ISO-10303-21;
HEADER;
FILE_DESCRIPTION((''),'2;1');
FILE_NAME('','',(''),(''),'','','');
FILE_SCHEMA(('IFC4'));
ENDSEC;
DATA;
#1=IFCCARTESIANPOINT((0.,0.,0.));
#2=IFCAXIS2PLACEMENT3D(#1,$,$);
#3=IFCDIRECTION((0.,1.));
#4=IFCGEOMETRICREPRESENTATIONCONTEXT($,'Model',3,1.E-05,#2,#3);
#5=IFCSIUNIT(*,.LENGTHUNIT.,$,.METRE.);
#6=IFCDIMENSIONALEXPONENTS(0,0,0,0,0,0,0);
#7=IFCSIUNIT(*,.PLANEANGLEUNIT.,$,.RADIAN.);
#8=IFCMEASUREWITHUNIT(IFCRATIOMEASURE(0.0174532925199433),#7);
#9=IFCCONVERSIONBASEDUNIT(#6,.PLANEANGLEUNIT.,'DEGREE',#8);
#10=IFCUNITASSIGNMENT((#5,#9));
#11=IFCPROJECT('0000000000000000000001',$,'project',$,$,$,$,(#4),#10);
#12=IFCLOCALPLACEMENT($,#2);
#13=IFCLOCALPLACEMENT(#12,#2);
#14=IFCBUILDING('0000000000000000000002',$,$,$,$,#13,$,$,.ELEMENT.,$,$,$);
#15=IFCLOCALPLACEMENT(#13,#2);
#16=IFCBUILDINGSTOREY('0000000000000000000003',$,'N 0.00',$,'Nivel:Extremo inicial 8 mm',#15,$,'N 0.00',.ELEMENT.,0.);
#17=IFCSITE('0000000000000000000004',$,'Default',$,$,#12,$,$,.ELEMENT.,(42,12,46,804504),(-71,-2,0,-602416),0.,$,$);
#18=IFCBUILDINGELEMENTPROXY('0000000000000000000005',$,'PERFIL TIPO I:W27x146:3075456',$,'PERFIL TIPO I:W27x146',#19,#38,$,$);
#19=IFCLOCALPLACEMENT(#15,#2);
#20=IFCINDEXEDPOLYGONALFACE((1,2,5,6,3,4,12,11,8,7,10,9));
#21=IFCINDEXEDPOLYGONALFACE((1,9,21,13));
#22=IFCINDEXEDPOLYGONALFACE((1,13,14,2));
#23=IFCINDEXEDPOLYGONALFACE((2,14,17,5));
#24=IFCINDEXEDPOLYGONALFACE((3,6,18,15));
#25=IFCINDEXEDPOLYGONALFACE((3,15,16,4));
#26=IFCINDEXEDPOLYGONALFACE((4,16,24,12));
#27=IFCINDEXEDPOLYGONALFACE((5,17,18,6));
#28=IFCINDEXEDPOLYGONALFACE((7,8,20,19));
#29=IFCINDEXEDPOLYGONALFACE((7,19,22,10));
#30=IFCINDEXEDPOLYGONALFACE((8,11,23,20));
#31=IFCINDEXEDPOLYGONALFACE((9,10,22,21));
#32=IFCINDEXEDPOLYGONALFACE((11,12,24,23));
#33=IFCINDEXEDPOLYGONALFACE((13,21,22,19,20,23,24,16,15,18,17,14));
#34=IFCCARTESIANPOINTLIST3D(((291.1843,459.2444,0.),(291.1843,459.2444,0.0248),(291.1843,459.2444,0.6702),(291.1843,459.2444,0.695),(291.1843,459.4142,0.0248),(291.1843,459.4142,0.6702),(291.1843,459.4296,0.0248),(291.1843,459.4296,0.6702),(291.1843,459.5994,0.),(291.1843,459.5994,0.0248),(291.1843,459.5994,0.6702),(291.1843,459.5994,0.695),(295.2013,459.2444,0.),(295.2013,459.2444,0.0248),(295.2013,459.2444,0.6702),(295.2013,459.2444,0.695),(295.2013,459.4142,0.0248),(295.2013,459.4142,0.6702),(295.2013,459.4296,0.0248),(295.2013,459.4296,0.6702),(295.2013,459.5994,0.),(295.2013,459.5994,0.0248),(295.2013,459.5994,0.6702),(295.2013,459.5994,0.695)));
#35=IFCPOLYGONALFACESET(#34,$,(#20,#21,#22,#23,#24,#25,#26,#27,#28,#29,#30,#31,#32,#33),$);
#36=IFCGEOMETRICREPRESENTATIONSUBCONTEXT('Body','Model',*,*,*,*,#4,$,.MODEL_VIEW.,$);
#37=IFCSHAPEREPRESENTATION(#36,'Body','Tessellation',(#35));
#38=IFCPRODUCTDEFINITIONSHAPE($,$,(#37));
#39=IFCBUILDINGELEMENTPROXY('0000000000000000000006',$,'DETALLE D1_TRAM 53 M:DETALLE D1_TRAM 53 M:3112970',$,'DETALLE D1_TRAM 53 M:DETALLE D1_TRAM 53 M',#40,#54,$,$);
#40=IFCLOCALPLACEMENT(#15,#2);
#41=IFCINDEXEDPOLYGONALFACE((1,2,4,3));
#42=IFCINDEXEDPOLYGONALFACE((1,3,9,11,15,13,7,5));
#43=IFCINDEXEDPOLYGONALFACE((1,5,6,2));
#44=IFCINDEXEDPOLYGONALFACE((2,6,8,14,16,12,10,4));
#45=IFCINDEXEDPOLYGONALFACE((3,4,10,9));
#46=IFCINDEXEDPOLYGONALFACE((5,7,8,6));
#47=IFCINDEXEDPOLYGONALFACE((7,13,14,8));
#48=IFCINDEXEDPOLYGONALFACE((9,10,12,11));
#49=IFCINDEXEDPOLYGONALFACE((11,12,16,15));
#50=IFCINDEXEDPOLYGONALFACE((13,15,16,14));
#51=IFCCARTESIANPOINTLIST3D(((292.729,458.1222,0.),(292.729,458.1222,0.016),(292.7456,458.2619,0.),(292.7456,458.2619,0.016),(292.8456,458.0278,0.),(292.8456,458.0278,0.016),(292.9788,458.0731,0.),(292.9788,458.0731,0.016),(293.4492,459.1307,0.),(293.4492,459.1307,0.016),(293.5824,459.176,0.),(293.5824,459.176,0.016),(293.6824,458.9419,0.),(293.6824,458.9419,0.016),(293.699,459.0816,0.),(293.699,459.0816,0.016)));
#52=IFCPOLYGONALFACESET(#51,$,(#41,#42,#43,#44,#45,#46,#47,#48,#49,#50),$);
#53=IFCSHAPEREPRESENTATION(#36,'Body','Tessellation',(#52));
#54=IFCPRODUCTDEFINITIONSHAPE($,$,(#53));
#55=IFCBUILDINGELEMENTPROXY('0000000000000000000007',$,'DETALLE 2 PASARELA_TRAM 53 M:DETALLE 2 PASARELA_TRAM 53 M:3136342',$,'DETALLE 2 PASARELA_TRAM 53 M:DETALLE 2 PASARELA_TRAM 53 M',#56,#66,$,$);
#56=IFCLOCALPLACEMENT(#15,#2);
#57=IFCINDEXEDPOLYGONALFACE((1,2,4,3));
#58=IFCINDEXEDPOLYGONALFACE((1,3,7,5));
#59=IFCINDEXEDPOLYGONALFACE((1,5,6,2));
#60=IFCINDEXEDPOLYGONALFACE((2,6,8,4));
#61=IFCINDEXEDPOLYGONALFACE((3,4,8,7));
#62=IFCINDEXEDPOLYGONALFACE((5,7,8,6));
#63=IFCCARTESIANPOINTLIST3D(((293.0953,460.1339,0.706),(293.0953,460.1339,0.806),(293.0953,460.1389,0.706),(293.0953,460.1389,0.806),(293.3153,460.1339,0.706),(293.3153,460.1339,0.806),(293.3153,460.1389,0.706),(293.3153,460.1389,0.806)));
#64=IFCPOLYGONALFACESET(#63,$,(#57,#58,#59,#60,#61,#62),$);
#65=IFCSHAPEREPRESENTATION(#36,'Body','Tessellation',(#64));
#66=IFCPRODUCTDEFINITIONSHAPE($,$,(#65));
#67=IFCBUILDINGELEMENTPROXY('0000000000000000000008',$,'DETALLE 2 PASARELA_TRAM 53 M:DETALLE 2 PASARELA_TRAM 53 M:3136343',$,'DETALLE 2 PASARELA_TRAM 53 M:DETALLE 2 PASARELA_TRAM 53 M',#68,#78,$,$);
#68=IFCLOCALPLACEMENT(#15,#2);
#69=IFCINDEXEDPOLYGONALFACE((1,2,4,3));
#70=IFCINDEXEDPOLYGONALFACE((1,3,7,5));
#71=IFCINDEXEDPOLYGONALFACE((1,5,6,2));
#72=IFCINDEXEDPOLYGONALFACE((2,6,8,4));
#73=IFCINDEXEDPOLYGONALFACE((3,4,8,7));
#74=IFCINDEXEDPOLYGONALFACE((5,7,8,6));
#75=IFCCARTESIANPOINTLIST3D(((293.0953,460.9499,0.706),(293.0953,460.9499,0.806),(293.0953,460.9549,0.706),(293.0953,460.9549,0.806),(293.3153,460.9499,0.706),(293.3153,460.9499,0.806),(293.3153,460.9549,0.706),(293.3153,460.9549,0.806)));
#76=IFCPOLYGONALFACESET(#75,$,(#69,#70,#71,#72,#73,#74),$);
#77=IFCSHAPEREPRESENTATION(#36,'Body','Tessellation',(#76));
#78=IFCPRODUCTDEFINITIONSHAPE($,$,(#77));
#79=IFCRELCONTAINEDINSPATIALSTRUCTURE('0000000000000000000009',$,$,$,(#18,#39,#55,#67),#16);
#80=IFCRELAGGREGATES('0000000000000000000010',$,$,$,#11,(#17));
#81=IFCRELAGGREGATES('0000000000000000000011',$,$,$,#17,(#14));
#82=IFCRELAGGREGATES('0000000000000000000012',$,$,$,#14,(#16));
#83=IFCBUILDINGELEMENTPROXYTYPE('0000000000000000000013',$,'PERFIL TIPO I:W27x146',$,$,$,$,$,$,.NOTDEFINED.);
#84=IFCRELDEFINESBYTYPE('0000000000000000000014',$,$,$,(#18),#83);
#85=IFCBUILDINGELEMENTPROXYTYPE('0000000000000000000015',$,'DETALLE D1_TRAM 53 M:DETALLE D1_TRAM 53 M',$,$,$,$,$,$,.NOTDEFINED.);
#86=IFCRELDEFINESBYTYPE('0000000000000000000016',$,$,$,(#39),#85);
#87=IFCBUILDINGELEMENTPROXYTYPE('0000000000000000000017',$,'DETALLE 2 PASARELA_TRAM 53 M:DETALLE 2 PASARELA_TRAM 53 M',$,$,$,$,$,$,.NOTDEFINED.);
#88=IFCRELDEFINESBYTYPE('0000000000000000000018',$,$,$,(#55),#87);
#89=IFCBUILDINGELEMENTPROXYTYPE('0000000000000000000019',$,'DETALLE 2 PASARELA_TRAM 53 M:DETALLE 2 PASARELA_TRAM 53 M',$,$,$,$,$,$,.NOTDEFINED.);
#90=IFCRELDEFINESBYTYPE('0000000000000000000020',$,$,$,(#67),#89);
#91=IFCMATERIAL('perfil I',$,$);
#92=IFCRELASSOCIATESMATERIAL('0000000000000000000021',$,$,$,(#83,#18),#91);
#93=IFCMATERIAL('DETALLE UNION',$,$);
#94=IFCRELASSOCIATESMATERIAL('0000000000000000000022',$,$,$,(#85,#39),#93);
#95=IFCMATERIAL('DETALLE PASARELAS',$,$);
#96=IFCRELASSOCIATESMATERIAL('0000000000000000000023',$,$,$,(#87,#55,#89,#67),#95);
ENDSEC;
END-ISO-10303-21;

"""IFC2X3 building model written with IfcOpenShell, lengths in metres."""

from ifc_helpers import new_model, entity, si_unit, converted_unit, direction, frame, frame_2d, origin, place, context, subcontext, project, spatial, polyline, rectangle, outline, extrude, source, transform, mapped, material, type_object, type_shapes, element, save


model = new_model("IFC2X3")

# Units and contexts
model_context = context("Model", 3, precision=1e-05, world=origin(), true_north=direction((0.0, 1.0)))
body_context = subcontext(model_context, "Body", "Model", "MODEL_VIEW")
ifc_project = project(units=[si_unit("LENGTHUNIT", "METRE"), converted_unit("PLANEANGLEUNIT", "DEGREE", entity("IfcRatioMeasure", 0.0174532925199433), si_unit("PLANEANGLEUNIT", "RADIAN"), dimensions=[0, 0, 0, 0, 0, 0, 0])], contexts=[model_context])

# Site, building, storey
site_placement = place(None, origin())
site = spatial("IfcSite", under=ifc_project, at=site_placement, Name="Default", CompositionType="ELEMENT", RefLatitude=(42, 12, 46, 804504), RefLongitude=(-71, -2, 0, -602416), RefElevation=0.0)
building_placement = place(site_placement, origin())
building = spatial("IfcBuilding", under=site, at=building_placement, CompositionType="ELEMENT")
storey_placement = place(building_placement, origin())
storey = spatial("IfcBuildingStorey", under=building, at=storey_placement, Name="N 0.00", ObjectType="Nivel:Extremo inicial 8 mm", LongName="N 0.00", CompositionType="ELEMENT", Elevation=0.0)

# Building element proxies
ifc_material_1 = material(Name="perfil I")
building_element_proxy_type_1 = type_object("IfcBuildingElementProxyType", Name="PERFIL TIPO I:W27x146", PredefinedType="NOTDEFINED", material=ifc_material_1)
shared_shape_1 = source(origin(), body_context, "Body", "SweptSolid", [
    extrude(outline(polyline([(0.3227, -0.1775), (0.3475, -0.1775), (0.3475, 0.1775), (0.3227, 0.1775), (0.3227, 0.0077), (-0.3227, 0.0077), (-0.3227, 0.1775), (-0.3475, 0.1775), (-0.3475, -0.1775), (-0.3227, -0.1775), (-0.3227, -0.0077), (0.3227, -0.0077), (0.3227, -0.1775)])), frame((0.0, 0.0, 0.3475), z_axis=(1.0, 0.0, 0.0), x_axis=(0.0, 0.0, 1.0)), (0.0, 0.0, 1.0), 4.017),
])
type_shapes(building_element_proxy_type_1, [shared_shape_1])
proxy_1_placement = place(storey_placement, frame((291.1843, 459.4219, 0.0)))
element("IfcBuildingElementProxy", 1, at=proxy_1_placement, inside=storey, type_object=building_element_proxy_type_1, material=ifc_material_1, Name="PERFIL TIPO I:W27x146:3075456", ObjectType="PERFIL TIPO I:W27x146", context=body_context, shape_type="MappedRepresentation", body=[
    mapped(shared_shape_1, transform((0.0, 0.0, 0.0), scale=1.0)),
])
ifc_material_2 = material(Name="DETALLE UNION")
building_element_proxy_type_2 = type_object("IfcBuildingElementProxyType", Name="DETALLE D1_TRAM 53 M:DETALLE D1_TRAM 53 M", PredefinedType="NOTDEFINED", material=ifc_material_2)
shared_shape_2 = source(origin(), body_context, "Body", "SweptSolid", [
    extrude(outline(polyline([(-0.075, -0.678), (0.075, -0.678), (0.15, -0.559), (0.15, 0.559), (0.075, 0.678), (-0.075, 0.678), (-0.15, 0.559), (-0.15, -0.559), (-0.075, -0.678)])), frame((0.0, 0.0, 0.0), z_axis=(0.0, 0.0, 1.0), x_axis=(-0.777146, 0.62932, 0.0)), (0.0, 0.0, 1.0), 0.016),
])
type_shapes(building_element_proxy_type_2, [shared_shape_2])
proxy_2_placement = place(storey_placement, frame((293.214, 458.6019, 0.0)))
element("IfcBuildingElementProxy", 2, at=proxy_2_placement, inside=storey, type_object=building_element_proxy_type_2, material=ifc_material_2, Name="DETALLE D1_TRAM 53 M:DETALLE D1_TRAM 53 M:3112970", ObjectType="DETALLE D1_TRAM 53 M:DETALLE D1_TRAM 53 M", context=body_context, shape_type="MappedRepresentation", body=[
    mapped(shared_shape_2, transform((0.0, 0.0, 0.0), scale=1.0)),
])
ifc_material_3 = material(Name="DETALLE PASARELAS")
building_element_proxy_type_3 = type_object("IfcBuildingElementProxyType", Name="DETALLE 2 PASARELA_TRAM 53 M:DETALLE 2 PASARELA_TRAM 53 M", PredefinedType="NOTDEFINED", material=ifc_material_3)
shared_shape_3 = source(origin(), body_context, "Body", "SweptSolid", [
    extrude(rectangle(XDim=0.22, YDim=0.005, at=frame_2d((0.0, 0.0), x_axis=(1.0, 0.0))), frame((0.11, 0.0475, 0.0), z_axis=(0.0, 0.0, 1.0), x_axis=(-1.0, 0.0, 0.0)), (0.0, 0.0, 1.0), 0.1),
])
type_shapes(building_element_proxy_type_3, [shared_shape_3])
proxy_3_placement = place(storey_placement, frame((293.0953, 460.0889, 0.706)))
element("IfcBuildingElementProxy", 3, at=proxy_3_placement, inside=storey, type_object=building_element_proxy_type_3, material=ifc_material_3, Name="DETALLE 2 PASARELA_TRAM 53 M:DETALLE 2 PASARELA_TRAM 53 M:3136342", ObjectType="DETALLE 2 PASARELA_TRAM 53 M:DETALLE 2 PASARELA_TRAM 53 M", context=body_context, shape_type="MappedRepresentation", body=[
    mapped(shared_shape_3, transform((0.0, 0.0, 0.0), scale=1.0)),
])
building_element_proxy_type_4 = type_object("IfcBuildingElementProxyType", Name="DETALLE 2 PASARELA_TRAM 53 M:DETALLE 2 PASARELA_TRAM 53 M", PredefinedType="NOTDEFINED", material=ifc_material_3)
shared_shape_4 = source(origin(), body_context, "Body", "SweptSolid", [
    extrude(rectangle(XDim=0.005, YDim=0.22, at=frame_2d((0.0, 0.0), x_axis=(1.0, 0.0))), frame((0.11, -0.0475, 0.0), z_axis=(0.0, 0.0, 1.0), x_axis=(0.0, 1.0, 0.0)), (0.0, 0.0, 1.0), 0.1),
])
type_shapes(building_element_proxy_type_4, [shared_shape_4])
proxy_4_placement = place(storey_placement, frame((293.0953, 460.9999, 0.706)))
element("IfcBuildingElementProxy", 4, at=proxy_4_placement, inside=storey, type_object=building_element_proxy_type_4, material=ifc_material_3, Name="DETALLE 2 PASARELA_TRAM 53 M:DETALLE 2 PASARELA_TRAM 53 M:3136343", ObjectType="DETALLE 2 PASARELA_TRAM 53 M:DETALLE 2 PASARELA_TRAM 53 M", context=body_context, shape_type="MappedRepresentation", body=[
    mapped(shared_shape_4, transform((0.0, 0.0, 0.0), scale=1.0)),
])

save(model, "model.ifc")
